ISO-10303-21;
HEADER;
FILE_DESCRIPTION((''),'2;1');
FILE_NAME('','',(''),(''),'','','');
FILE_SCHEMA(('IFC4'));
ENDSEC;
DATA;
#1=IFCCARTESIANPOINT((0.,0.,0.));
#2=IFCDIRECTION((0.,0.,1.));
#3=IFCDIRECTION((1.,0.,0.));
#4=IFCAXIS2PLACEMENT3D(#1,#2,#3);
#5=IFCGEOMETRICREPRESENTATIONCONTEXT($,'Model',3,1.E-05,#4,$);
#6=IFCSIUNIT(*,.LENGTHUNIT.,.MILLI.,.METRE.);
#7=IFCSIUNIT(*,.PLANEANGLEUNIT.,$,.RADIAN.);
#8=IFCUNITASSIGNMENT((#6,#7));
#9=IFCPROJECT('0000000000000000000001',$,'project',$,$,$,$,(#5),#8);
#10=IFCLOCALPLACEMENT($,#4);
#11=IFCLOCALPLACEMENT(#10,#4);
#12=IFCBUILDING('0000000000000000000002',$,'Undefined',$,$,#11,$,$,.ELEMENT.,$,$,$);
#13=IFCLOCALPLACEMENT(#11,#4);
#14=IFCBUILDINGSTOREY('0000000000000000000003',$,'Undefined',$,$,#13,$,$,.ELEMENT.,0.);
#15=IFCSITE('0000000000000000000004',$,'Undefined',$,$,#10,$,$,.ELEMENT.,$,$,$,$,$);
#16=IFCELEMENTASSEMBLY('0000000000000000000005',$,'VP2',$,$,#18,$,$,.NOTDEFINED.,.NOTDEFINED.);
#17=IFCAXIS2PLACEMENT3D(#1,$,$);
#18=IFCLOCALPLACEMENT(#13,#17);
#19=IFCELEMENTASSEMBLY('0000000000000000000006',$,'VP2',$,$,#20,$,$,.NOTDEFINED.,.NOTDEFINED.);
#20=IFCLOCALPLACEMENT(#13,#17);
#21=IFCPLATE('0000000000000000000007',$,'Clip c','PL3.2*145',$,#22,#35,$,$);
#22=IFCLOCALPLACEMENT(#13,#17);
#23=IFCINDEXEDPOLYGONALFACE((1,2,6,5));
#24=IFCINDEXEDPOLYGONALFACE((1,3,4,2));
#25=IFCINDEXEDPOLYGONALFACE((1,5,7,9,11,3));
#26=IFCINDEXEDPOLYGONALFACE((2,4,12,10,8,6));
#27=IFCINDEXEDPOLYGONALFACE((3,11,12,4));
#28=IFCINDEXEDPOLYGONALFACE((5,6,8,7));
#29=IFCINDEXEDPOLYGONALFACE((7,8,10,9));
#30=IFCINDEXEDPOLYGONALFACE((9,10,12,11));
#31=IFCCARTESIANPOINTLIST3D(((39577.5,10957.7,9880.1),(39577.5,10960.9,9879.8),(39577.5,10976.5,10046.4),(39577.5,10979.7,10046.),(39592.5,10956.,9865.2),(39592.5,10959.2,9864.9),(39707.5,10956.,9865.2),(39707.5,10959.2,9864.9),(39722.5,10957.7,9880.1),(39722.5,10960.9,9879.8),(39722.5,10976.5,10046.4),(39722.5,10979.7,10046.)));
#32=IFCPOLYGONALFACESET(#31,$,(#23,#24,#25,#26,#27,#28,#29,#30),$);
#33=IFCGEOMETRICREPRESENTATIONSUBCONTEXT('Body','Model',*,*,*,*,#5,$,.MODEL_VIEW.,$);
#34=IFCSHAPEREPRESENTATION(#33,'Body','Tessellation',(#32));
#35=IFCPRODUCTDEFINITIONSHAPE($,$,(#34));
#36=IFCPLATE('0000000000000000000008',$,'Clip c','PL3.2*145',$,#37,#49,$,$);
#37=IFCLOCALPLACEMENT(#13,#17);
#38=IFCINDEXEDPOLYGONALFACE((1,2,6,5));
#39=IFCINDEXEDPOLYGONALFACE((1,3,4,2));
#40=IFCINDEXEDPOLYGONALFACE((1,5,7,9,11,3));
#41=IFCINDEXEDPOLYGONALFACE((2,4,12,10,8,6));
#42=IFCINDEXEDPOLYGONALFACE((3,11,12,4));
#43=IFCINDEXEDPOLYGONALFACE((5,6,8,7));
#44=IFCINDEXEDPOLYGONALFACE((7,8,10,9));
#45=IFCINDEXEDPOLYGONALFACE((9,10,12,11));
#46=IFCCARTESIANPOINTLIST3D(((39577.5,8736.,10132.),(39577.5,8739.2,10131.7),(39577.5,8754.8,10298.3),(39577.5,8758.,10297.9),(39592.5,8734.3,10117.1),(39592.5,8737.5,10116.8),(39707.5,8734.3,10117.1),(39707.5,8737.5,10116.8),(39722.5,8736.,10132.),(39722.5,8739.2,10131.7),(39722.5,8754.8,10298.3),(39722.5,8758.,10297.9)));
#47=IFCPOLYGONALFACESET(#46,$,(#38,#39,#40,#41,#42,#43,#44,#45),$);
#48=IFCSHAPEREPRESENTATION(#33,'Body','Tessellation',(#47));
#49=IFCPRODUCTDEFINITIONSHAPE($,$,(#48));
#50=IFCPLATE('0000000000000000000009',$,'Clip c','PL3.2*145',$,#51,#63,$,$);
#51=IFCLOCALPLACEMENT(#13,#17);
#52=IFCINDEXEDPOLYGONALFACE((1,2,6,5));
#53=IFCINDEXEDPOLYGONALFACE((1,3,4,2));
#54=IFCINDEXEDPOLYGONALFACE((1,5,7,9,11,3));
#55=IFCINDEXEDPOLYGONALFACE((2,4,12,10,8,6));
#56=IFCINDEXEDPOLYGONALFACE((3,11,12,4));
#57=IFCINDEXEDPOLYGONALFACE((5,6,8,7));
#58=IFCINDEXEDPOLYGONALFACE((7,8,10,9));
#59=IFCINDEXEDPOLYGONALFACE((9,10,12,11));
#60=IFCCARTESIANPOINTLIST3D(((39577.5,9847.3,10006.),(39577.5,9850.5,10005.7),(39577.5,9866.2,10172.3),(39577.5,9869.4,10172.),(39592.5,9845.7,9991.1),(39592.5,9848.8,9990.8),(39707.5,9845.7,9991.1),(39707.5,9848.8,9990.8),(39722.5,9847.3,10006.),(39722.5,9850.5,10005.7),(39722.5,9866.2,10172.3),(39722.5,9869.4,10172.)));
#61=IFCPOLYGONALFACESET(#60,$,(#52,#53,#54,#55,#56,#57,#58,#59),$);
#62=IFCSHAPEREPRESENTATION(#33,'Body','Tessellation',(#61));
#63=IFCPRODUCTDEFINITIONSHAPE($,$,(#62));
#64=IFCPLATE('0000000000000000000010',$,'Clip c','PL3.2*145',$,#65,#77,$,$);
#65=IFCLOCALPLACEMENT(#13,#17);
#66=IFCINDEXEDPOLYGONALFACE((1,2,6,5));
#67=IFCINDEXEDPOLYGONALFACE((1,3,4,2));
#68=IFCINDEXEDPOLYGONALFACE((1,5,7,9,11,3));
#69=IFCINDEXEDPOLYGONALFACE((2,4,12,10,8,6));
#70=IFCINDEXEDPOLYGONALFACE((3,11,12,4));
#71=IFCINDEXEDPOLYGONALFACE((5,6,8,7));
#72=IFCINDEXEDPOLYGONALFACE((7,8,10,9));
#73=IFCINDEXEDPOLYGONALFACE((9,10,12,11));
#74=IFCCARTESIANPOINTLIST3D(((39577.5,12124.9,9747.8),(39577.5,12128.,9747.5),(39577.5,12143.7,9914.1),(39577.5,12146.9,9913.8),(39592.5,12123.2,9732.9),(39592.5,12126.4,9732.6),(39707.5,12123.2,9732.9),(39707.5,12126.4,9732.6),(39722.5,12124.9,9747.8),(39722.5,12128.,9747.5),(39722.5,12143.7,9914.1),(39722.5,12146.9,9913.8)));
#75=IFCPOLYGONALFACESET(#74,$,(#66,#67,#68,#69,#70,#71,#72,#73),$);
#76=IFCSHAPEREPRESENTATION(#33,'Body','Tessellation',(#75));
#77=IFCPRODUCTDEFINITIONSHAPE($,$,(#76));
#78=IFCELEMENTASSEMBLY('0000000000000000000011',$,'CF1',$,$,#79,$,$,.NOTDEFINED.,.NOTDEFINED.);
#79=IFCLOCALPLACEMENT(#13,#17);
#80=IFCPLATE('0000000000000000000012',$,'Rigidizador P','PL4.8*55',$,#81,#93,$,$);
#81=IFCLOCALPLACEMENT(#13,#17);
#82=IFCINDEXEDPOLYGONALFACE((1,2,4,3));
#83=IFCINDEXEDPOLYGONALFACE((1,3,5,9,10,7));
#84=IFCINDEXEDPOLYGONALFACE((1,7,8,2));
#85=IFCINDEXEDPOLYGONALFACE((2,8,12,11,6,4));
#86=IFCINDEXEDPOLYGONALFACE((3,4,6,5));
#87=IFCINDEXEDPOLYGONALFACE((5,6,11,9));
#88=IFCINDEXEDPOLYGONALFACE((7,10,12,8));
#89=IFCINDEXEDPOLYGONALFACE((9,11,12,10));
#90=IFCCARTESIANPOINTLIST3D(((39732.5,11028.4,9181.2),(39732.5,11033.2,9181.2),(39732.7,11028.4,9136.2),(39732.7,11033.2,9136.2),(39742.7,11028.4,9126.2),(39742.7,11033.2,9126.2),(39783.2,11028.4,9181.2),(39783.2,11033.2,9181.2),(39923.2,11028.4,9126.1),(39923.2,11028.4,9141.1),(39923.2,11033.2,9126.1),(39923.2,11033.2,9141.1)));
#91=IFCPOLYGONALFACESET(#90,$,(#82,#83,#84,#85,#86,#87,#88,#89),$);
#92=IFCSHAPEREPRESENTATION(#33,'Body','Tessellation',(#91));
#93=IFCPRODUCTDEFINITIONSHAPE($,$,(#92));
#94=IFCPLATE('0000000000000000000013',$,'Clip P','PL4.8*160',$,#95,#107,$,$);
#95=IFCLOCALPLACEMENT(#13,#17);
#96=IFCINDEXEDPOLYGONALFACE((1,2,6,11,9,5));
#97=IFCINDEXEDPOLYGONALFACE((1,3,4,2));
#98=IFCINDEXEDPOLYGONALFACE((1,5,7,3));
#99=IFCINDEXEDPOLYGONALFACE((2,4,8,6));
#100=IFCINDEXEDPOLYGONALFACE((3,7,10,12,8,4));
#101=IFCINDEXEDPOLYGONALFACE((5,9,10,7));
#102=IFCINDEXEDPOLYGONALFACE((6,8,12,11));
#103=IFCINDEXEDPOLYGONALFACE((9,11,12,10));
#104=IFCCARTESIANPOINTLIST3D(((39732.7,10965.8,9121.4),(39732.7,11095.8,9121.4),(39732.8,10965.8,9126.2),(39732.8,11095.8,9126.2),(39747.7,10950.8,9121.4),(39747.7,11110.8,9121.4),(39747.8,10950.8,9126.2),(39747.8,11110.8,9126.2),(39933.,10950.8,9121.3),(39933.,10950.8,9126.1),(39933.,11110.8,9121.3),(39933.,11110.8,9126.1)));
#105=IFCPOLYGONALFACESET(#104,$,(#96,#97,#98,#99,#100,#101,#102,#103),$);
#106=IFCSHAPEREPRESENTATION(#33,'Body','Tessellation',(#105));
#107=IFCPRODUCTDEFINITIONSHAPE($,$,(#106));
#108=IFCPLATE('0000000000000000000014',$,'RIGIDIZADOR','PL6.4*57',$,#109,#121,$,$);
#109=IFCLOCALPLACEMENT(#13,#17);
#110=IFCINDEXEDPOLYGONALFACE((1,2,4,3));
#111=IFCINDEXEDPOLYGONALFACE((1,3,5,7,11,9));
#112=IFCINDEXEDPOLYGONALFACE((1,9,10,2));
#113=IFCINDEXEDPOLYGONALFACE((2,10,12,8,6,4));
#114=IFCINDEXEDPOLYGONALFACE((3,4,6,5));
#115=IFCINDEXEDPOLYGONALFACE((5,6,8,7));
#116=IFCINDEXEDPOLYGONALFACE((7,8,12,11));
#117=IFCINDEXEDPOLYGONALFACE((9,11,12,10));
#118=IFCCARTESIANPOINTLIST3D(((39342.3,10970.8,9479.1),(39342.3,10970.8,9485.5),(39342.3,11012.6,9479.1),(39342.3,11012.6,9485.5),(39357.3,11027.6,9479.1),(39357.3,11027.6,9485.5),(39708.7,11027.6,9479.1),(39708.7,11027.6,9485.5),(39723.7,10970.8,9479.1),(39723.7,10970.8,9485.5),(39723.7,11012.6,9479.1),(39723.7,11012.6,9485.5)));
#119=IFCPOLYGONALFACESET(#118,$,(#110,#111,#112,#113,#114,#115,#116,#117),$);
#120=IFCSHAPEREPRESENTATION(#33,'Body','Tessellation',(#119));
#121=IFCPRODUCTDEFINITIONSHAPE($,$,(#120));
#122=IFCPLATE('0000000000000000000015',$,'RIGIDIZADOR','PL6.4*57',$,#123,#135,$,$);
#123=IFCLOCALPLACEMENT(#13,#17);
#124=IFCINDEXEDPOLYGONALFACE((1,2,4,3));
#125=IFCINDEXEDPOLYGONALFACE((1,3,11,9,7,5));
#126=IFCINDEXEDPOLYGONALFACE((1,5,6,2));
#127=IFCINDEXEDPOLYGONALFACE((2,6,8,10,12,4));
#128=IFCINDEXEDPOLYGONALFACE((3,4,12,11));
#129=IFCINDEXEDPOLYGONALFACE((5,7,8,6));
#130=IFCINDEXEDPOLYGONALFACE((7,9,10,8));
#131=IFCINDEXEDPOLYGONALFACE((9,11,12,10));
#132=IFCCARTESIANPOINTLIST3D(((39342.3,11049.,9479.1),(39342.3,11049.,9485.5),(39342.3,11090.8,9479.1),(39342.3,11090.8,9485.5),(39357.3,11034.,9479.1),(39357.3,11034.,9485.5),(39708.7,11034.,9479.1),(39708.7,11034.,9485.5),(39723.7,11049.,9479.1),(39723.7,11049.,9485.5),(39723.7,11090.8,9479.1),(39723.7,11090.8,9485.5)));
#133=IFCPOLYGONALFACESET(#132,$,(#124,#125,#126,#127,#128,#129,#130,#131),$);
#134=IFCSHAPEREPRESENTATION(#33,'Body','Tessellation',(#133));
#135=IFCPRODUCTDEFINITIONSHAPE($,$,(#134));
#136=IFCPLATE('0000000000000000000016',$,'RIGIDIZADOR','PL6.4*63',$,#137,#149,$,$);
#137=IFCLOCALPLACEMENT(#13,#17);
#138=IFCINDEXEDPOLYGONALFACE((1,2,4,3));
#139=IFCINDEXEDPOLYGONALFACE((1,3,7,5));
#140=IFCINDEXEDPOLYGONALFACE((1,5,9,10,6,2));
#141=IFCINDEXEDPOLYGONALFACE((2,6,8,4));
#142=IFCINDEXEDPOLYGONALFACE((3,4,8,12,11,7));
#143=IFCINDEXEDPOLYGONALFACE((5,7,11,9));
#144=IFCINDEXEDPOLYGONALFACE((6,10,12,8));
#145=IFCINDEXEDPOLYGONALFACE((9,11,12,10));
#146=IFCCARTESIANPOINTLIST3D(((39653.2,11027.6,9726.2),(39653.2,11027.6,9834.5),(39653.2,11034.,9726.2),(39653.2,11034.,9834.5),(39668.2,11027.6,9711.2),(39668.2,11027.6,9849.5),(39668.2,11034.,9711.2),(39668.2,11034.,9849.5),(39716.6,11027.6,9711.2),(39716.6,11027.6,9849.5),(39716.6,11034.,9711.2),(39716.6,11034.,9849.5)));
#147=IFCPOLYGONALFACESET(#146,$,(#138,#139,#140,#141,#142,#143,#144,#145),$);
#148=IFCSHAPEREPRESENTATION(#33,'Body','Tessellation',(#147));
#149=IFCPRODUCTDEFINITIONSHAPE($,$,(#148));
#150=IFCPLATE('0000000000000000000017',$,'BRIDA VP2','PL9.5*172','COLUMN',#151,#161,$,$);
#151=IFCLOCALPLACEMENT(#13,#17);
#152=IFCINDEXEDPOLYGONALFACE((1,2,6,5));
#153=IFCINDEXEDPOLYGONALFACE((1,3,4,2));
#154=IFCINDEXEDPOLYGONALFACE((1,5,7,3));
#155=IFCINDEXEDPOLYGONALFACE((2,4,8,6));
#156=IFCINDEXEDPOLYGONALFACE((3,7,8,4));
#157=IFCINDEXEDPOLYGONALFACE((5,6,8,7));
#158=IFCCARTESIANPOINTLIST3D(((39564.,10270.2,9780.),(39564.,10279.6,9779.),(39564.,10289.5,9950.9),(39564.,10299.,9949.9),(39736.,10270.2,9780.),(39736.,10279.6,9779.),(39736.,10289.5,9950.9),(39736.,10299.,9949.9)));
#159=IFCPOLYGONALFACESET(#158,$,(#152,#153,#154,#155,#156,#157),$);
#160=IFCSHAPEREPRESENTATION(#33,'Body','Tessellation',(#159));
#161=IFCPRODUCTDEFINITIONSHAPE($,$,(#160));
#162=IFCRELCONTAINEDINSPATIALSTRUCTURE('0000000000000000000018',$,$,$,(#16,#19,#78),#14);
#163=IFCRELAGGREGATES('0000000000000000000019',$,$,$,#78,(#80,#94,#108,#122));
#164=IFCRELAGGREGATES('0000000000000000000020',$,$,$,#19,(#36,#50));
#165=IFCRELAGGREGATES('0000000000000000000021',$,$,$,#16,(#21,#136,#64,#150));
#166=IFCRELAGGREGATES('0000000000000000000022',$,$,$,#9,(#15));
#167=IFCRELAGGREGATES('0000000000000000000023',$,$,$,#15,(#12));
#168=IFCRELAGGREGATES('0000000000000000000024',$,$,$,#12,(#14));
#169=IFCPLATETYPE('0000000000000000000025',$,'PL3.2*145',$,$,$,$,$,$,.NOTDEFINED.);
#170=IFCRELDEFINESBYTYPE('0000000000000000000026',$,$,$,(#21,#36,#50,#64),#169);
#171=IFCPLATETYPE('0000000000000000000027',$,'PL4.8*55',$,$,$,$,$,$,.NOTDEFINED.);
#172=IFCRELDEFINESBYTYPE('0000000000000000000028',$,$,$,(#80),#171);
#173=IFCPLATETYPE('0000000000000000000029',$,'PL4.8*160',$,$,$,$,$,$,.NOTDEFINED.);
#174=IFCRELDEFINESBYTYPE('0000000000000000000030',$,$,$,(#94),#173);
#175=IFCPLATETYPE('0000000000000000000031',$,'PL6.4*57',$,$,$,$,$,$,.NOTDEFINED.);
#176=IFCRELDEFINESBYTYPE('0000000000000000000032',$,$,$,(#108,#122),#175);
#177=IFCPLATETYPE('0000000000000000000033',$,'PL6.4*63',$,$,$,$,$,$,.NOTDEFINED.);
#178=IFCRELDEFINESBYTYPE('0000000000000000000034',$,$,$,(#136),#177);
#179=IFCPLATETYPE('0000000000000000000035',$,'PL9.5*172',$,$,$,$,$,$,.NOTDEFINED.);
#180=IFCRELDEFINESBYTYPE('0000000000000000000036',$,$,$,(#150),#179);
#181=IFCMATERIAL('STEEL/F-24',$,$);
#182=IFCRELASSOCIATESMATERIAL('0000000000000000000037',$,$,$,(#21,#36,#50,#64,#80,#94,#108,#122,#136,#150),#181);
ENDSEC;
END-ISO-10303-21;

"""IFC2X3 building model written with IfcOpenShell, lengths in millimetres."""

from ifc_helpers import new_model, si_unit, frame, origin_with_axes, place, context, subcontext, project, spatial, polyline, outline, extrude, material, type_object, element, aggregate, save


model = new_model("IFC2X3")

# Units and contexts
model_context = context("Model", 3, precision=1e-05, world=origin_with_axes())
body_context = subcontext(model_context, "Body", "Model", "MODEL_VIEW")
ifc_project = project(units=[si_unit("LENGTHUNIT", "METRE", prefix="MILLI"), si_unit("PLANEANGLEUNIT", "RADIAN")], contexts=[model_context])

# Site, building, storey
site_placement = place(None, origin_with_axes())
site = spatial("IfcSite", under=ifc_project, at=site_placement, Name="Undefined", CompositionType="ELEMENT")
building_placement = place(site_placement, origin_with_axes())
building = spatial("IfcBuilding", under=site, at=building_placement, Name="Undefined", CompositionType="ELEMENT")
storey_placement = place(building_placement, origin_with_axes())
storey = spatial("IfcBuildingStorey", under=building, at=storey_placement, Name="Undefined", CompositionType="ELEMENT", Elevation=0.0)

# Element assembly
assembly_1_placement = place(storey_placement, origin_with_axes())
assembly_1 = element("IfcElementAssembly", 1, at=assembly_1_placement, inside=storey, Name="VP2", AssemblyPlace="NOTDEFINED", PredefinedType="NOTDEFINED")

# Shared definitions
ifc_material_1 = material(Name="STEEL/F-24")

# Element assembly
assembly_2_placement = place(storey_placement, origin_with_axes())
assembly_2 = element("IfcElementAssembly", 2, at=assembly_2_placement, inside=storey, Name="VP2", AssemblyPlace="NOTDEFINED", PredefinedType="NOTDEFINED")

# Plates
plate_type_1 = type_object("IfcPlateType", Name="PL3.2*145", PredefinedType="NOTDEFINED")
plate_1_placement = place(assembly_1_placement, frame((39722.5, 10957.6, 9865.0), z_axis=(0.0, -0.993645, 0.112559), x_axis=(0.0, 0.112559, 0.993645)))
plate_1 = element("IfcPlate", 3, at=plate_1_placement, type_object=plate_type_1, material=ifc_material_1, Name="Clip c", Description="PL3.2*145", context=body_context, shape_type="SweptSolid", body=[
    extrude(outline(polyline([(0.0, 15.0), (15.0, 0.0), (182.3, 0.0), (182.3, 145.0), (15.0, 145.0), (0.0, 130.0), (0.0, 15.0)])), frame((0.0, 0.0, -1.6), z_axis=(0.0, 0.0, 1.0), x_axis=(1.0, 0.0, 0.0)), (0.0, 0.0, 1.0), 3.2),
])
plate_2_placement = place(assembly_2_placement, frame((39722.5, 8735.9, 10116.9), z_axis=(0.0, -0.993645, 0.112559), x_axis=(0.0, 0.112559, 0.993645)))
plate_2 = element("IfcPlate", 4, at=plate_2_placement, type_object=plate_type_1, material=ifc_material_1, Name="Clip c", Description="PL3.2*145", context=body_context, shape_type="SweptSolid", body=[
    extrude(outline(polyline([(0.0, 15.0), (15.0, 0.0), (182.3, 0.0), (182.3, 145.0), (15.0, 145.0), (0.0, 130.0), (0.0, 15.0)])), frame((0.0, 0.0, -1.6), z_axis=(0.0, 0.0, 1.0), x_axis=(1.0, 0.0, 0.0)), (0.0, 0.0, 1.0), 3.2),
])
plate_3_placement = place(assembly_2_placement, frame((39722.5, 9847.2, 9991.0), z_axis=(0.0, -0.993645, 0.112559), x_axis=(0.0, 0.112559, 0.993645)))
plate_3 = element("IfcPlate", 5, at=plate_3_placement, type_object=plate_type_1, material=ifc_material_1, Name="Clip c", Description="PL3.2*145", context=body_context, shape_type="SweptSolid", body=[
    extrude(outline(polyline([(0.0, 15.0), (15.0, 0.0), (182.3, 0.0), (182.3, 145.0), (15.0, 145.0), (0.0, 130.0), (0.0, 15.0)])), frame((0.0, 0.0, -1.6), z_axis=(0.0, 0.0, 1.0), x_axis=(1.0, 0.0, 0.0)), (0.0, 0.0, 1.0), 3.2),
])
plate_4_placement = place(assembly_1_placement, frame((39722.5, 12124.8, 9732.8), z_axis=(0.0, -0.993645, 0.112559), x_axis=(0.0, 0.112559, 0.993645)))
plate_4 = element("IfcPlate", 6, at=plate_4_placement, type_object=plate_type_1, material=ifc_material_1, Name="Clip c", Description="PL3.2*145", context=body_context, shape_type="SweptSolid", body=[
    extrude(outline(polyline([(0.0, 15.0), (15.0, 0.0), (182.3, 0.0), (182.3, 145.0), (15.0, 145.0), (0.0, 130.0), (0.0, 15.0)])), frame((0.0, 0.0, -1.6), z_axis=(0.0, 0.0, 1.0), x_axis=(1.0, 0.0, 0.0)), (0.0, 0.0, 1.0), 3.2),
])

# Element assembly, plates
assembly_3_placement = place(storey_placement, origin_with_axes())
assembly_3 = element("IfcElementAssembly", 7, at=assembly_3_placement, inside=storey, Name="CF1", AssemblyPlace="NOTDEFINED", PredefinedType="NOTDEFINED")
plate_type_2 = type_object("IfcPlateType", Name="PL4.8*55", PredefinedType="NOTDEFINED")
plate_5_placement = place(assembly_3_placement, frame((39923.2, 11030.8, 9126.1), z_axis=(0.0, -1.0, 0.0), x_axis=(0.000256, 0.0, 1.0)))
plate_5 = element("IfcPlate", 8, at=plate_5_placement, type_object=plate_type_2, material=ifc_material_1, Name="Rigidizador P", Description="PL4.8*55", context=body_context, shape_type="SweptSolid", body=[
    extrude(outline(polyline([(0.0, 0.0), (15.0, 0.0), (55.0, 140.0), (55.1, 190.7), (10.1, 190.5), (0.1, 180.4), (0.0, 0.0)])), frame((0.0, 0.0, -2.4), z_axis=(0.0, 0.0, 1.0), x_axis=(1.0, 0.0, 0.0)), (0.0, 0.0, 1.0), 4.8),
])
plate_type_3 = type_object("IfcPlateType", Name="PL4.8*160", PredefinedType="NOTDEFINED")
plate_6_placement = place(assembly_3_placement, frame((39732.7, 10950.8, 9123.8), z_axis=(0.000554, 0.0, 1.0), x_axis=(1.0, 0.0, -0.000554)))
plate_6 = element("IfcPlate", 9, at=plate_6_placement, type_object=plate_type_3, material=ifc_material_1, Name="Clip P", Description="PL4.8*160", context=body_context, shape_type="SweptSolid", body=[
    extrude(outline(polyline([(0.0, 15.0), (15.0, 0.0), (200.3, 0.0), (200.3, 160.0), (15.0, 160.0), (0.0, 145.0), (0.0, 15.0)])), frame((0.0, 0.0, -2.4), z_axis=(0.0, 0.0, 1.0), x_axis=(1.0, 0.0, 0.0)), (0.0, 0.0, 1.0), 4.8),
])
plate_type_4 = type_object("IfcPlateType", Name="PL6.4*57", PredefinedType="NOTDEFINED")
plate_7_placement = place(assembly_3_placement, frame((39723.7, 10970.8, 9482.3), z_axis=(0.0, 0.0, 1.0), x_axis=(0.0, 1.0, 0.0)))
plate_7 = element("IfcPlate", 10, at=plate_7_placement, type_object=plate_type_4, material=ifc_material_1, Name="RIGIDIZADOR", Description="PL6.4*57", context=body_context, shape_type="SweptSolid", body=[
    extrude(outline(polyline([(0.0, 0.0), (41.8, 0.0), (56.8, 15.0), (56.8, 366.4), (41.8, 381.4), (0.0, 381.4), (0.0, 0.0)])), frame((0.0, 0.0, -3.2), z_axis=(0.0, 0.0, 1.0), x_axis=(1.0, 0.0, 0.0)), (0.0, 0.0, 1.0), 6.4),
])
plate_8_placement = place(assembly_3_placement, frame((39723.7, 11034.0, 9482.3), z_axis=(0.0, 0.0, 1.0), x_axis=(0.0, 1.0, 0.0)))
plate_8 = element("IfcPlate", 11, at=plate_8_placement, type_object=plate_type_4, material=ifc_material_1, Name="RIGIDIZADOR", Description="PL6.4*57", context=body_context, shape_type="SweptSolid", body=[
    extrude(outline(polyline([(0.0, 15.0), (15.0, 0.0), (56.8, 0.0), (56.8, 381.4), (15.0, 381.4), (0.0, 366.4), (0.0, 15.0)])), frame((0.0, 0.0, -3.2), z_axis=(0.0, 0.0, 1.0), x_axis=(1.0, 0.0, 0.0)), (0.0, 0.0, 1.0), 6.4),
])
aggregate(assembly_3, [plate_5, plate_6, plate_7, plate_8])

# Plates
plate_type_5 = type_object("IfcPlateType", Name="PL6.4*63", PredefinedType="NOTDEFINED")
plate_9_placement = place(assembly_1_placement, frame((39716.6, 11030.8, 9711.2), z_axis=(0.0, 1.0, 0.0), x_axis=(-1.0, 0.0, 0.0)))
plate_9 = element("IfcPlate", 12, at=plate_9_placement, type_object=plate_type_5, material=ifc_material_1, Name="RIGIDIZADOR", Description="PL6.4*63", context=body_context, shape_type="SweptSolid", body=[
    extrude(outline(polyline([(0.0, 0.0), (48.4, 0.0), (63.4, 15.0), (63.4, 123.4), (48.4, 138.4), (0.0, 138.4), (0.0, 0.0)])), frame((0.0, 0.0, -3.2), z_axis=(0.0, 0.0, 1.0), x_axis=(1.0, 0.0, 0.0)), (0.0, 0.0, 1.0), 6.4),
])
plate_type_6 = type_object("IfcPlateType", Name="PL9.5*172", PredefinedType="NOTDEFINED")
plate_10_placement = place(assembly_1_placement, frame((39650.0, 10294.3, 9950.4), z_axis=(0.0, 0.993634, -0.112653), x_axis=(0.0, -0.112653, -0.993634)))
plate_10 = element("IfcPlate", 13, at=plate_10_placement, type_object=plate_type_6, material=ifc_material_1, Name="BRIDA VP2", Description="PL9.5*172", ObjectType="COLUMN", context=body_context, shape_type="SweptSolid", body=[
    extrude(outline(polyline([(0.0, -86.0), (0.0, 86.0), (172.0, 86.0), (172.0, -86.0), (0.0, -86.0)])), frame((0.0, 0.0, -4.8), z_axis=(0.0, 0.0, 1.0), x_axis=(1.0, 0.0, 0.0)), (0.0, 0.0, 1.0), 9.5),
])

aggregate(assembly_2, [plate_2, plate_3])
aggregate(assembly_1, [plate_1, plate_9, plate_4, plate_10])

save(model, "model.ifc")
